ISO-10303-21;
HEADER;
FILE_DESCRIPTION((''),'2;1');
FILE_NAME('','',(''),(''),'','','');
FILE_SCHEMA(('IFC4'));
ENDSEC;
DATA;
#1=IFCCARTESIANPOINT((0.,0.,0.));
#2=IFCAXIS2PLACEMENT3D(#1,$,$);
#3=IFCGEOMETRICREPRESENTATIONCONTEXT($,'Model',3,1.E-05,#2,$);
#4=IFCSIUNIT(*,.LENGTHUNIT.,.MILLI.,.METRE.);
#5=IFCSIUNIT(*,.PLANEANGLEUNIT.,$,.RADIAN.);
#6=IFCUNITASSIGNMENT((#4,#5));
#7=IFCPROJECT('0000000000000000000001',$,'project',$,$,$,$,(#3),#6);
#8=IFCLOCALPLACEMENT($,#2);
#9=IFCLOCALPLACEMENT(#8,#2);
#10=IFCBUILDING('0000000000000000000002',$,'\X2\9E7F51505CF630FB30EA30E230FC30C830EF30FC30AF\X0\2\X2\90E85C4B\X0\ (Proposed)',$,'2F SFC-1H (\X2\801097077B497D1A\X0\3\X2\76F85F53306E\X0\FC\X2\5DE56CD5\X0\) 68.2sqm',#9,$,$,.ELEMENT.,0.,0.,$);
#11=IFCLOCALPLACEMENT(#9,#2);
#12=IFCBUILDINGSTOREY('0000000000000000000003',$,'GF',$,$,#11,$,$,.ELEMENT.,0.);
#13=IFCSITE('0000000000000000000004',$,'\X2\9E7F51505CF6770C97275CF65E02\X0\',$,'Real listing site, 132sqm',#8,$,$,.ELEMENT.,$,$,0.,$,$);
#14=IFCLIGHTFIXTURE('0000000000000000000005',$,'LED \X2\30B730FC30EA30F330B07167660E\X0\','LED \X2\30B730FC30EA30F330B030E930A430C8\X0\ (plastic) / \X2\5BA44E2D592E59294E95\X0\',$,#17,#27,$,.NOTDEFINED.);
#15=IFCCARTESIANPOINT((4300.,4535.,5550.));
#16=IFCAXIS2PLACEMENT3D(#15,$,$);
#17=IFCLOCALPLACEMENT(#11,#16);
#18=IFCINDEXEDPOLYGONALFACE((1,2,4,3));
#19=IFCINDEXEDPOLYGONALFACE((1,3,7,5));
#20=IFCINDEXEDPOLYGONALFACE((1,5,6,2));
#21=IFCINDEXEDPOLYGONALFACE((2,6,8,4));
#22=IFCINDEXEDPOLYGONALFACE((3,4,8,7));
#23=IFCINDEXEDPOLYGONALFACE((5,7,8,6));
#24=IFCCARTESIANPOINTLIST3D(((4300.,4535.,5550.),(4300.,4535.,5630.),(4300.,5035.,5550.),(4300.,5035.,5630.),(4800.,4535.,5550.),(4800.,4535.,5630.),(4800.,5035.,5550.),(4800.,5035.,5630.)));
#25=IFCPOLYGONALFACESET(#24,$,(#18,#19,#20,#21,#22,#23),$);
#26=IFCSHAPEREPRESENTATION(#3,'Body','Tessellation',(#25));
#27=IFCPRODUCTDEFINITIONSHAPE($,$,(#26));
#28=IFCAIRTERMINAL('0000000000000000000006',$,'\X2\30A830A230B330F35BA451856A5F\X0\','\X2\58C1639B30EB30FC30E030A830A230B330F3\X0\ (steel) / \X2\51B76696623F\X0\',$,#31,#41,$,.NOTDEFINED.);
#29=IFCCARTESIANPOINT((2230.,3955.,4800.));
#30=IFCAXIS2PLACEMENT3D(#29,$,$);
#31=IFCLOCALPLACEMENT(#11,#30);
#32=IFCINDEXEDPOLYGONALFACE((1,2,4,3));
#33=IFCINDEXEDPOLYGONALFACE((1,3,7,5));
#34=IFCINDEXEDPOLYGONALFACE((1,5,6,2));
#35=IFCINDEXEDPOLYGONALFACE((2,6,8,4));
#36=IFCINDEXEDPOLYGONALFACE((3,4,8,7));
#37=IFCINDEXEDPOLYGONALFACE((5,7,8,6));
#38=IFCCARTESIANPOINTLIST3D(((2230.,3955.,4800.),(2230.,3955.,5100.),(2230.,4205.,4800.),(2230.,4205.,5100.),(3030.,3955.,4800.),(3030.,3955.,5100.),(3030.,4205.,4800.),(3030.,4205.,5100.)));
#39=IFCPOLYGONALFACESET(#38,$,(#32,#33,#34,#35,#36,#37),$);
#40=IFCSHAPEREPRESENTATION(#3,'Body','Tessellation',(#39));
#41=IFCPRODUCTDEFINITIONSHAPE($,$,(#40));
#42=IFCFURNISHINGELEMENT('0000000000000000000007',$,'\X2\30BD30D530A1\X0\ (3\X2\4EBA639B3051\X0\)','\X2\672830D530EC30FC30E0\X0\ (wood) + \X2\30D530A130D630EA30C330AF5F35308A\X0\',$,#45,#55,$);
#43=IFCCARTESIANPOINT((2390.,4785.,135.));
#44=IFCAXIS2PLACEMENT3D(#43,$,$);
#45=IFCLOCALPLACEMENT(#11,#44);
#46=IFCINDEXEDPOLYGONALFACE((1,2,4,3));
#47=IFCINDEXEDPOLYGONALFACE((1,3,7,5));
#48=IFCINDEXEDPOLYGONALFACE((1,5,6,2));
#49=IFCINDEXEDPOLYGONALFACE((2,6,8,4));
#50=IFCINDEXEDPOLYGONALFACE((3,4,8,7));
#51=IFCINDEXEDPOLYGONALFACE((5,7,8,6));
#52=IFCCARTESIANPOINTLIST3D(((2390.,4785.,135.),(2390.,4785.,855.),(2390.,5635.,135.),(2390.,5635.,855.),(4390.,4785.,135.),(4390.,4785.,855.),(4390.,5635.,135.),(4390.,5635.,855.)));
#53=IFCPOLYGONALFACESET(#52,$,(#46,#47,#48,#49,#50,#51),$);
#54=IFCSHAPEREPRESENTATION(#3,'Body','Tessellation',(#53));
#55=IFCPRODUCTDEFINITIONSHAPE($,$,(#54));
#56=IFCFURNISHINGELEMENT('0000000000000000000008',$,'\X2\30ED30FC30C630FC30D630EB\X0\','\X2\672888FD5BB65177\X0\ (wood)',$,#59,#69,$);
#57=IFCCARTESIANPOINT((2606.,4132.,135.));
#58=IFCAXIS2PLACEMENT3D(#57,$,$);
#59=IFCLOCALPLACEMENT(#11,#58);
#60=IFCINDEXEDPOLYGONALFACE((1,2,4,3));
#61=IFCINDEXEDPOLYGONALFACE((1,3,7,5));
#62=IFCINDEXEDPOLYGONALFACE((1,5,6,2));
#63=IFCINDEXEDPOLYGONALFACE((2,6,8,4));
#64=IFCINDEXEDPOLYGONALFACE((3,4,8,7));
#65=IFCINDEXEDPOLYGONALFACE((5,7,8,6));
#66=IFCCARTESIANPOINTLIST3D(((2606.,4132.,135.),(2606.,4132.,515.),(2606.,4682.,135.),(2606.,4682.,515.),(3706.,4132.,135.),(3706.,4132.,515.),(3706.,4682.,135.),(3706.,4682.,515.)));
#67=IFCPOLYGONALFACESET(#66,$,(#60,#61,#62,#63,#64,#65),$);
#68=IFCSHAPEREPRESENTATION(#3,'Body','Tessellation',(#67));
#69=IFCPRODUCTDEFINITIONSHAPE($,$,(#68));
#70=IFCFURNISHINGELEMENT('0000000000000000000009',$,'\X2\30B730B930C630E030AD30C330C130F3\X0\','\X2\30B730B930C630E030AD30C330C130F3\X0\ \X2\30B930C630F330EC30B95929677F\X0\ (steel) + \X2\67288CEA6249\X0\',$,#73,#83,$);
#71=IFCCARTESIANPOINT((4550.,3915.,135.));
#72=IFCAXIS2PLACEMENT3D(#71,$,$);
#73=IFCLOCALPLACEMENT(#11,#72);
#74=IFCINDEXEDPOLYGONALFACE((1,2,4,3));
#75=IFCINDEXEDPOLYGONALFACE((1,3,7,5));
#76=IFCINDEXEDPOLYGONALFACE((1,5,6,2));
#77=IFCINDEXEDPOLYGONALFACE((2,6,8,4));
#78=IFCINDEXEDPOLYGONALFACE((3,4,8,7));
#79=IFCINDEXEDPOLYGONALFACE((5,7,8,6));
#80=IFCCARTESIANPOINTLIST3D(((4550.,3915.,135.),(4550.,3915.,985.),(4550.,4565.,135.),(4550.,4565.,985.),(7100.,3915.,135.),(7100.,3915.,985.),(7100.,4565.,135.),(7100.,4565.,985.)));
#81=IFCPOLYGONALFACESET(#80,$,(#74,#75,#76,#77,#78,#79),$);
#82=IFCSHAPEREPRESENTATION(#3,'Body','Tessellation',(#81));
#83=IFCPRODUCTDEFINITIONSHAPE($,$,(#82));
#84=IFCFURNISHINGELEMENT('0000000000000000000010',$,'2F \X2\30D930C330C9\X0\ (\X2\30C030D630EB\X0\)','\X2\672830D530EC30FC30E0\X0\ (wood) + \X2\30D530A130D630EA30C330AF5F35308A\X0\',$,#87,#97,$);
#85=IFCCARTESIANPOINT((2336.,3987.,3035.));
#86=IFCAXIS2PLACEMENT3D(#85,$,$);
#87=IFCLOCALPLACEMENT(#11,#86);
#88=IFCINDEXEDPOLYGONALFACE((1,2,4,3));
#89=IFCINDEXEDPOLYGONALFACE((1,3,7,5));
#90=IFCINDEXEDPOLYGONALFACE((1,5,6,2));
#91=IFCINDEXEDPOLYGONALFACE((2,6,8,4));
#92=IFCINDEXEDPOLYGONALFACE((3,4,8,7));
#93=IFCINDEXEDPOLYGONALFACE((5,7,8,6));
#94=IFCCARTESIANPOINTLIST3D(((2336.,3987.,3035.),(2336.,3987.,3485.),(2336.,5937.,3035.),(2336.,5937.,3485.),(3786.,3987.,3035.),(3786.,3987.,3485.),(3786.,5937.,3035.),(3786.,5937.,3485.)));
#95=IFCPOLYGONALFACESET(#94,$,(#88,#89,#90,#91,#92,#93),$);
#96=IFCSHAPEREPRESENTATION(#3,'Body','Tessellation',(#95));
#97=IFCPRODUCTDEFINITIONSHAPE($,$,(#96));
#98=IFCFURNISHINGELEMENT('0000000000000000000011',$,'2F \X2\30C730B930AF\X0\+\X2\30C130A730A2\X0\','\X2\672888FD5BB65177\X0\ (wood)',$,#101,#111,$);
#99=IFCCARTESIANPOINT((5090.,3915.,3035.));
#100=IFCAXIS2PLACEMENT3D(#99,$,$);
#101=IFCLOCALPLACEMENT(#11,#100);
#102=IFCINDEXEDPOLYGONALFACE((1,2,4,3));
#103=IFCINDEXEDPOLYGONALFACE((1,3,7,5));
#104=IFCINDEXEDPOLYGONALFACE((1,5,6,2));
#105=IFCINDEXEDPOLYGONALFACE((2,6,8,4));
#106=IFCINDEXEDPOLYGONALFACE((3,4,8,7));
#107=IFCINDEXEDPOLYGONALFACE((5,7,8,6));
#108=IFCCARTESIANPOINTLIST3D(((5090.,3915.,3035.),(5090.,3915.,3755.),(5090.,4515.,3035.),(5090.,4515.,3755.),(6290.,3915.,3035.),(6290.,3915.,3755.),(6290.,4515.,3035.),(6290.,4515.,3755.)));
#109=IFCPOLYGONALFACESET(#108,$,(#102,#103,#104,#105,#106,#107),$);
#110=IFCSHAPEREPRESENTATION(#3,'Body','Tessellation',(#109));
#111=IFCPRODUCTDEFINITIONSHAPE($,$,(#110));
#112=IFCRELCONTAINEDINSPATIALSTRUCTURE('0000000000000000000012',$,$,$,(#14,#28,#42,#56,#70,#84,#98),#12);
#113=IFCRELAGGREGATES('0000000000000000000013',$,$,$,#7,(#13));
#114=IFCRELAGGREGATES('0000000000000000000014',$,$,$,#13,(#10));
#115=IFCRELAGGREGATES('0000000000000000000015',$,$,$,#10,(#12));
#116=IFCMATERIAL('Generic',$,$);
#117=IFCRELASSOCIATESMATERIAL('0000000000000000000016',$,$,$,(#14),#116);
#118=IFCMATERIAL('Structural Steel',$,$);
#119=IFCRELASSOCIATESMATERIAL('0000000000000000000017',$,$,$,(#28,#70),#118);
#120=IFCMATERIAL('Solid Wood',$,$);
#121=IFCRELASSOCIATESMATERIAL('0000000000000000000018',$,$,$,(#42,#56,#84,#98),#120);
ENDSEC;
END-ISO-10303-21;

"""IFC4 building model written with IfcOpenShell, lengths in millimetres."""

from ifc_helpers import new_model, si_unit, frame, frame_2d, origin, place, context, project, spatial, rectangle, extrude, material, element, save


model = new_model("IFC4")

# Units and contexts
model_context = context("Model", 3, precision=1e-05, world=origin())
ifc_project = project(units=[si_unit("LENGTHUNIT", "METRE", prefix="MILLI"), si_unit("PLANEANGLEUNIT", "RADIAN")], contexts=[model_context])

# Site, building, storey
site_placement = place(None, origin())
site = spatial("IfcSite", under=ifc_project, at=site_placement, Name="鹿児島県霧島市", ObjectType="Real listing site, 132sqm", CompositionType="ELEMENT", RefElevation=0.0)
building_placement = place(site_placement, origin())
building = spatial("IfcBuilding", under=site, at=building_placement, Name="鹿児島・リモートワーク2部屋 (Proposed)", ObjectType="2F SFC-1H (耐震等級3相当のFC工法) 68.2sqm", CompositionType="ELEMENT", ElevationOfRefHeight=0.0, ElevationOfTerrain=0.0)
storey_placement = place(building_placement, origin())
storey = spatial("IfcBuildingStorey", under=building, at=storey_placement, Name="GF", CompositionType="ELEMENT", Elevation=0.0)

# Shared definitions
ifc_material_1 = material(Name="Solid Wood")

# Shared definitions
ifc_material_2 = material(Name="Generic")

# Shared definitions
ifc_material_3 = material(Name="Structural Steel")

# Light fixture
light_fixture_1_placement = place(storey_placement, frame((4300.0, 4535.0, 5550.0)))
element("IfcLightFixture", 1, at=light_fixture_1_placement, inside=storey, material=ifc_material_2, Name="LED シーリング照明", Description="LED シーリングライト (plastic) / 室中央天井", PredefinedType="NOTDEFINED", context=model_context, shape_type="SweptSolid", body=[
    extrude(rectangle(XDim=500.0, YDim=500.0, at=frame_2d((250.0, 250.0))), frame((4300.0, 4535.0, 5550.0)), (0.0, 0.0, 1.0), 80.0),
])

# Air terminal
air_terminal_placement = place(storey_placement, frame((2230.0, 3955.0, 4800.0)))
element("IfcAirTerminal", 2, at=air_terminal_placement, inside=storey, material=ifc_material_3, Name="エアコン室内機", Description="壁掛ルームエアコン (steel) / 冷暖房", PredefinedType="NOTDEFINED", context=model_context, shape_type="SweptSolid", body=[
    extrude(rectangle(XDim=800.0, YDim=250.0, at=frame_2d((400.0, 125.0))), frame((2230.0, 3955.0, 4800.0)), (0.0, 0.0, 1.0), 300.0),
])

# Furnishing elements
furnishing_1_placement = place(storey_placement, frame((2390.0, 4785.0, 135.0)))
element("IfcFurnishingElement", 3, at=furnishing_1_placement, inside=storey, material=ifc_material_1, Name="ソファ (3人掛け)", Description="木フレーム (wood) + ファブリック張り", context=model_context, shape_type="SweptSolid", body=[
    extrude(rectangle(XDim=2000.0, YDim=850.0, at=frame_2d((1000.0, 425.0))), frame((2390.0, 4785.0, 135.0)), (0.0, 0.0, 1.0), 720.0),
])
furnishing_2_placement = place(storey_placement, frame((2606.0, 4132.0, 135.0)))
element("IfcFurnishingElement", 4, at=furnishing_2_placement, inside=storey, material=ifc_material_1, Name="ローテーブル", Description="木製家具 (wood)", context=model_context, shape_type="SweptSolid", body=[
    extrude(rectangle(XDim=1100.0, YDim=550.0, at=frame_2d((550.0, 275.0))), frame((2606.0, 4132.0, 135.0)), (0.0, 0.0, 1.0), 380.0),
])
furnishing_3_placement = place(storey_placement, frame((4550.0, 3915.0, 135.0)))
element("IfcFurnishingElement", 5, at=furnishing_3_placement, inside=storey, material=ifc_material_3, Name="システムキッチン", Description="システムキッチン ステンレス天板 (steel) + 木質扉", context=model_context, shape_type="SweptSolid", body=[
    extrude(rectangle(XDim=2550.0, YDim=650.0, at=frame_2d((1275.0, 325.0))), frame((4550.0, 3915.0, 135.0)), (0.0, 0.0, 1.0), 850.0),
])
furnishing_4_placement = place(storey_placement, frame((2336.0, 3987.0, 3035.0)))
element("IfcFurnishingElement", 6, at=furnishing_4_placement, inside=storey, material=ifc_material_1, Name="2F ベッド (ダブル)", Description="木フレーム (wood) + ファブリック張り", context=model_context, shape_type="SweptSolid", body=[
    extrude(rectangle(XDim=1450.0, YDim=1950.0, at=frame_2d((725.0, 975.0))), frame((2336.0, 3987.0, 3035.0)), (0.0, 0.0, 1.0), 450.0),
])
furnishing_5_placement = place(storey_placement, frame((5090.0, 3915.0, 3035.0)))
element("IfcFurnishingElement", 7, at=furnishing_5_placement, inside=storey, material=ifc_material_1, Name="2F デスク+チェア", Description="木製家具 (wood)", context=model_context, shape_type="SweptSolid", body=[
    extrude(rectangle(XDim=1200.0, YDim=600.0, at=frame_2d((600.0, 300.0))), frame((5090.0, 3915.0, 3035.0)), (0.0, 0.0, 1.0), 720.0),
])

save(model, "model.ifc")
